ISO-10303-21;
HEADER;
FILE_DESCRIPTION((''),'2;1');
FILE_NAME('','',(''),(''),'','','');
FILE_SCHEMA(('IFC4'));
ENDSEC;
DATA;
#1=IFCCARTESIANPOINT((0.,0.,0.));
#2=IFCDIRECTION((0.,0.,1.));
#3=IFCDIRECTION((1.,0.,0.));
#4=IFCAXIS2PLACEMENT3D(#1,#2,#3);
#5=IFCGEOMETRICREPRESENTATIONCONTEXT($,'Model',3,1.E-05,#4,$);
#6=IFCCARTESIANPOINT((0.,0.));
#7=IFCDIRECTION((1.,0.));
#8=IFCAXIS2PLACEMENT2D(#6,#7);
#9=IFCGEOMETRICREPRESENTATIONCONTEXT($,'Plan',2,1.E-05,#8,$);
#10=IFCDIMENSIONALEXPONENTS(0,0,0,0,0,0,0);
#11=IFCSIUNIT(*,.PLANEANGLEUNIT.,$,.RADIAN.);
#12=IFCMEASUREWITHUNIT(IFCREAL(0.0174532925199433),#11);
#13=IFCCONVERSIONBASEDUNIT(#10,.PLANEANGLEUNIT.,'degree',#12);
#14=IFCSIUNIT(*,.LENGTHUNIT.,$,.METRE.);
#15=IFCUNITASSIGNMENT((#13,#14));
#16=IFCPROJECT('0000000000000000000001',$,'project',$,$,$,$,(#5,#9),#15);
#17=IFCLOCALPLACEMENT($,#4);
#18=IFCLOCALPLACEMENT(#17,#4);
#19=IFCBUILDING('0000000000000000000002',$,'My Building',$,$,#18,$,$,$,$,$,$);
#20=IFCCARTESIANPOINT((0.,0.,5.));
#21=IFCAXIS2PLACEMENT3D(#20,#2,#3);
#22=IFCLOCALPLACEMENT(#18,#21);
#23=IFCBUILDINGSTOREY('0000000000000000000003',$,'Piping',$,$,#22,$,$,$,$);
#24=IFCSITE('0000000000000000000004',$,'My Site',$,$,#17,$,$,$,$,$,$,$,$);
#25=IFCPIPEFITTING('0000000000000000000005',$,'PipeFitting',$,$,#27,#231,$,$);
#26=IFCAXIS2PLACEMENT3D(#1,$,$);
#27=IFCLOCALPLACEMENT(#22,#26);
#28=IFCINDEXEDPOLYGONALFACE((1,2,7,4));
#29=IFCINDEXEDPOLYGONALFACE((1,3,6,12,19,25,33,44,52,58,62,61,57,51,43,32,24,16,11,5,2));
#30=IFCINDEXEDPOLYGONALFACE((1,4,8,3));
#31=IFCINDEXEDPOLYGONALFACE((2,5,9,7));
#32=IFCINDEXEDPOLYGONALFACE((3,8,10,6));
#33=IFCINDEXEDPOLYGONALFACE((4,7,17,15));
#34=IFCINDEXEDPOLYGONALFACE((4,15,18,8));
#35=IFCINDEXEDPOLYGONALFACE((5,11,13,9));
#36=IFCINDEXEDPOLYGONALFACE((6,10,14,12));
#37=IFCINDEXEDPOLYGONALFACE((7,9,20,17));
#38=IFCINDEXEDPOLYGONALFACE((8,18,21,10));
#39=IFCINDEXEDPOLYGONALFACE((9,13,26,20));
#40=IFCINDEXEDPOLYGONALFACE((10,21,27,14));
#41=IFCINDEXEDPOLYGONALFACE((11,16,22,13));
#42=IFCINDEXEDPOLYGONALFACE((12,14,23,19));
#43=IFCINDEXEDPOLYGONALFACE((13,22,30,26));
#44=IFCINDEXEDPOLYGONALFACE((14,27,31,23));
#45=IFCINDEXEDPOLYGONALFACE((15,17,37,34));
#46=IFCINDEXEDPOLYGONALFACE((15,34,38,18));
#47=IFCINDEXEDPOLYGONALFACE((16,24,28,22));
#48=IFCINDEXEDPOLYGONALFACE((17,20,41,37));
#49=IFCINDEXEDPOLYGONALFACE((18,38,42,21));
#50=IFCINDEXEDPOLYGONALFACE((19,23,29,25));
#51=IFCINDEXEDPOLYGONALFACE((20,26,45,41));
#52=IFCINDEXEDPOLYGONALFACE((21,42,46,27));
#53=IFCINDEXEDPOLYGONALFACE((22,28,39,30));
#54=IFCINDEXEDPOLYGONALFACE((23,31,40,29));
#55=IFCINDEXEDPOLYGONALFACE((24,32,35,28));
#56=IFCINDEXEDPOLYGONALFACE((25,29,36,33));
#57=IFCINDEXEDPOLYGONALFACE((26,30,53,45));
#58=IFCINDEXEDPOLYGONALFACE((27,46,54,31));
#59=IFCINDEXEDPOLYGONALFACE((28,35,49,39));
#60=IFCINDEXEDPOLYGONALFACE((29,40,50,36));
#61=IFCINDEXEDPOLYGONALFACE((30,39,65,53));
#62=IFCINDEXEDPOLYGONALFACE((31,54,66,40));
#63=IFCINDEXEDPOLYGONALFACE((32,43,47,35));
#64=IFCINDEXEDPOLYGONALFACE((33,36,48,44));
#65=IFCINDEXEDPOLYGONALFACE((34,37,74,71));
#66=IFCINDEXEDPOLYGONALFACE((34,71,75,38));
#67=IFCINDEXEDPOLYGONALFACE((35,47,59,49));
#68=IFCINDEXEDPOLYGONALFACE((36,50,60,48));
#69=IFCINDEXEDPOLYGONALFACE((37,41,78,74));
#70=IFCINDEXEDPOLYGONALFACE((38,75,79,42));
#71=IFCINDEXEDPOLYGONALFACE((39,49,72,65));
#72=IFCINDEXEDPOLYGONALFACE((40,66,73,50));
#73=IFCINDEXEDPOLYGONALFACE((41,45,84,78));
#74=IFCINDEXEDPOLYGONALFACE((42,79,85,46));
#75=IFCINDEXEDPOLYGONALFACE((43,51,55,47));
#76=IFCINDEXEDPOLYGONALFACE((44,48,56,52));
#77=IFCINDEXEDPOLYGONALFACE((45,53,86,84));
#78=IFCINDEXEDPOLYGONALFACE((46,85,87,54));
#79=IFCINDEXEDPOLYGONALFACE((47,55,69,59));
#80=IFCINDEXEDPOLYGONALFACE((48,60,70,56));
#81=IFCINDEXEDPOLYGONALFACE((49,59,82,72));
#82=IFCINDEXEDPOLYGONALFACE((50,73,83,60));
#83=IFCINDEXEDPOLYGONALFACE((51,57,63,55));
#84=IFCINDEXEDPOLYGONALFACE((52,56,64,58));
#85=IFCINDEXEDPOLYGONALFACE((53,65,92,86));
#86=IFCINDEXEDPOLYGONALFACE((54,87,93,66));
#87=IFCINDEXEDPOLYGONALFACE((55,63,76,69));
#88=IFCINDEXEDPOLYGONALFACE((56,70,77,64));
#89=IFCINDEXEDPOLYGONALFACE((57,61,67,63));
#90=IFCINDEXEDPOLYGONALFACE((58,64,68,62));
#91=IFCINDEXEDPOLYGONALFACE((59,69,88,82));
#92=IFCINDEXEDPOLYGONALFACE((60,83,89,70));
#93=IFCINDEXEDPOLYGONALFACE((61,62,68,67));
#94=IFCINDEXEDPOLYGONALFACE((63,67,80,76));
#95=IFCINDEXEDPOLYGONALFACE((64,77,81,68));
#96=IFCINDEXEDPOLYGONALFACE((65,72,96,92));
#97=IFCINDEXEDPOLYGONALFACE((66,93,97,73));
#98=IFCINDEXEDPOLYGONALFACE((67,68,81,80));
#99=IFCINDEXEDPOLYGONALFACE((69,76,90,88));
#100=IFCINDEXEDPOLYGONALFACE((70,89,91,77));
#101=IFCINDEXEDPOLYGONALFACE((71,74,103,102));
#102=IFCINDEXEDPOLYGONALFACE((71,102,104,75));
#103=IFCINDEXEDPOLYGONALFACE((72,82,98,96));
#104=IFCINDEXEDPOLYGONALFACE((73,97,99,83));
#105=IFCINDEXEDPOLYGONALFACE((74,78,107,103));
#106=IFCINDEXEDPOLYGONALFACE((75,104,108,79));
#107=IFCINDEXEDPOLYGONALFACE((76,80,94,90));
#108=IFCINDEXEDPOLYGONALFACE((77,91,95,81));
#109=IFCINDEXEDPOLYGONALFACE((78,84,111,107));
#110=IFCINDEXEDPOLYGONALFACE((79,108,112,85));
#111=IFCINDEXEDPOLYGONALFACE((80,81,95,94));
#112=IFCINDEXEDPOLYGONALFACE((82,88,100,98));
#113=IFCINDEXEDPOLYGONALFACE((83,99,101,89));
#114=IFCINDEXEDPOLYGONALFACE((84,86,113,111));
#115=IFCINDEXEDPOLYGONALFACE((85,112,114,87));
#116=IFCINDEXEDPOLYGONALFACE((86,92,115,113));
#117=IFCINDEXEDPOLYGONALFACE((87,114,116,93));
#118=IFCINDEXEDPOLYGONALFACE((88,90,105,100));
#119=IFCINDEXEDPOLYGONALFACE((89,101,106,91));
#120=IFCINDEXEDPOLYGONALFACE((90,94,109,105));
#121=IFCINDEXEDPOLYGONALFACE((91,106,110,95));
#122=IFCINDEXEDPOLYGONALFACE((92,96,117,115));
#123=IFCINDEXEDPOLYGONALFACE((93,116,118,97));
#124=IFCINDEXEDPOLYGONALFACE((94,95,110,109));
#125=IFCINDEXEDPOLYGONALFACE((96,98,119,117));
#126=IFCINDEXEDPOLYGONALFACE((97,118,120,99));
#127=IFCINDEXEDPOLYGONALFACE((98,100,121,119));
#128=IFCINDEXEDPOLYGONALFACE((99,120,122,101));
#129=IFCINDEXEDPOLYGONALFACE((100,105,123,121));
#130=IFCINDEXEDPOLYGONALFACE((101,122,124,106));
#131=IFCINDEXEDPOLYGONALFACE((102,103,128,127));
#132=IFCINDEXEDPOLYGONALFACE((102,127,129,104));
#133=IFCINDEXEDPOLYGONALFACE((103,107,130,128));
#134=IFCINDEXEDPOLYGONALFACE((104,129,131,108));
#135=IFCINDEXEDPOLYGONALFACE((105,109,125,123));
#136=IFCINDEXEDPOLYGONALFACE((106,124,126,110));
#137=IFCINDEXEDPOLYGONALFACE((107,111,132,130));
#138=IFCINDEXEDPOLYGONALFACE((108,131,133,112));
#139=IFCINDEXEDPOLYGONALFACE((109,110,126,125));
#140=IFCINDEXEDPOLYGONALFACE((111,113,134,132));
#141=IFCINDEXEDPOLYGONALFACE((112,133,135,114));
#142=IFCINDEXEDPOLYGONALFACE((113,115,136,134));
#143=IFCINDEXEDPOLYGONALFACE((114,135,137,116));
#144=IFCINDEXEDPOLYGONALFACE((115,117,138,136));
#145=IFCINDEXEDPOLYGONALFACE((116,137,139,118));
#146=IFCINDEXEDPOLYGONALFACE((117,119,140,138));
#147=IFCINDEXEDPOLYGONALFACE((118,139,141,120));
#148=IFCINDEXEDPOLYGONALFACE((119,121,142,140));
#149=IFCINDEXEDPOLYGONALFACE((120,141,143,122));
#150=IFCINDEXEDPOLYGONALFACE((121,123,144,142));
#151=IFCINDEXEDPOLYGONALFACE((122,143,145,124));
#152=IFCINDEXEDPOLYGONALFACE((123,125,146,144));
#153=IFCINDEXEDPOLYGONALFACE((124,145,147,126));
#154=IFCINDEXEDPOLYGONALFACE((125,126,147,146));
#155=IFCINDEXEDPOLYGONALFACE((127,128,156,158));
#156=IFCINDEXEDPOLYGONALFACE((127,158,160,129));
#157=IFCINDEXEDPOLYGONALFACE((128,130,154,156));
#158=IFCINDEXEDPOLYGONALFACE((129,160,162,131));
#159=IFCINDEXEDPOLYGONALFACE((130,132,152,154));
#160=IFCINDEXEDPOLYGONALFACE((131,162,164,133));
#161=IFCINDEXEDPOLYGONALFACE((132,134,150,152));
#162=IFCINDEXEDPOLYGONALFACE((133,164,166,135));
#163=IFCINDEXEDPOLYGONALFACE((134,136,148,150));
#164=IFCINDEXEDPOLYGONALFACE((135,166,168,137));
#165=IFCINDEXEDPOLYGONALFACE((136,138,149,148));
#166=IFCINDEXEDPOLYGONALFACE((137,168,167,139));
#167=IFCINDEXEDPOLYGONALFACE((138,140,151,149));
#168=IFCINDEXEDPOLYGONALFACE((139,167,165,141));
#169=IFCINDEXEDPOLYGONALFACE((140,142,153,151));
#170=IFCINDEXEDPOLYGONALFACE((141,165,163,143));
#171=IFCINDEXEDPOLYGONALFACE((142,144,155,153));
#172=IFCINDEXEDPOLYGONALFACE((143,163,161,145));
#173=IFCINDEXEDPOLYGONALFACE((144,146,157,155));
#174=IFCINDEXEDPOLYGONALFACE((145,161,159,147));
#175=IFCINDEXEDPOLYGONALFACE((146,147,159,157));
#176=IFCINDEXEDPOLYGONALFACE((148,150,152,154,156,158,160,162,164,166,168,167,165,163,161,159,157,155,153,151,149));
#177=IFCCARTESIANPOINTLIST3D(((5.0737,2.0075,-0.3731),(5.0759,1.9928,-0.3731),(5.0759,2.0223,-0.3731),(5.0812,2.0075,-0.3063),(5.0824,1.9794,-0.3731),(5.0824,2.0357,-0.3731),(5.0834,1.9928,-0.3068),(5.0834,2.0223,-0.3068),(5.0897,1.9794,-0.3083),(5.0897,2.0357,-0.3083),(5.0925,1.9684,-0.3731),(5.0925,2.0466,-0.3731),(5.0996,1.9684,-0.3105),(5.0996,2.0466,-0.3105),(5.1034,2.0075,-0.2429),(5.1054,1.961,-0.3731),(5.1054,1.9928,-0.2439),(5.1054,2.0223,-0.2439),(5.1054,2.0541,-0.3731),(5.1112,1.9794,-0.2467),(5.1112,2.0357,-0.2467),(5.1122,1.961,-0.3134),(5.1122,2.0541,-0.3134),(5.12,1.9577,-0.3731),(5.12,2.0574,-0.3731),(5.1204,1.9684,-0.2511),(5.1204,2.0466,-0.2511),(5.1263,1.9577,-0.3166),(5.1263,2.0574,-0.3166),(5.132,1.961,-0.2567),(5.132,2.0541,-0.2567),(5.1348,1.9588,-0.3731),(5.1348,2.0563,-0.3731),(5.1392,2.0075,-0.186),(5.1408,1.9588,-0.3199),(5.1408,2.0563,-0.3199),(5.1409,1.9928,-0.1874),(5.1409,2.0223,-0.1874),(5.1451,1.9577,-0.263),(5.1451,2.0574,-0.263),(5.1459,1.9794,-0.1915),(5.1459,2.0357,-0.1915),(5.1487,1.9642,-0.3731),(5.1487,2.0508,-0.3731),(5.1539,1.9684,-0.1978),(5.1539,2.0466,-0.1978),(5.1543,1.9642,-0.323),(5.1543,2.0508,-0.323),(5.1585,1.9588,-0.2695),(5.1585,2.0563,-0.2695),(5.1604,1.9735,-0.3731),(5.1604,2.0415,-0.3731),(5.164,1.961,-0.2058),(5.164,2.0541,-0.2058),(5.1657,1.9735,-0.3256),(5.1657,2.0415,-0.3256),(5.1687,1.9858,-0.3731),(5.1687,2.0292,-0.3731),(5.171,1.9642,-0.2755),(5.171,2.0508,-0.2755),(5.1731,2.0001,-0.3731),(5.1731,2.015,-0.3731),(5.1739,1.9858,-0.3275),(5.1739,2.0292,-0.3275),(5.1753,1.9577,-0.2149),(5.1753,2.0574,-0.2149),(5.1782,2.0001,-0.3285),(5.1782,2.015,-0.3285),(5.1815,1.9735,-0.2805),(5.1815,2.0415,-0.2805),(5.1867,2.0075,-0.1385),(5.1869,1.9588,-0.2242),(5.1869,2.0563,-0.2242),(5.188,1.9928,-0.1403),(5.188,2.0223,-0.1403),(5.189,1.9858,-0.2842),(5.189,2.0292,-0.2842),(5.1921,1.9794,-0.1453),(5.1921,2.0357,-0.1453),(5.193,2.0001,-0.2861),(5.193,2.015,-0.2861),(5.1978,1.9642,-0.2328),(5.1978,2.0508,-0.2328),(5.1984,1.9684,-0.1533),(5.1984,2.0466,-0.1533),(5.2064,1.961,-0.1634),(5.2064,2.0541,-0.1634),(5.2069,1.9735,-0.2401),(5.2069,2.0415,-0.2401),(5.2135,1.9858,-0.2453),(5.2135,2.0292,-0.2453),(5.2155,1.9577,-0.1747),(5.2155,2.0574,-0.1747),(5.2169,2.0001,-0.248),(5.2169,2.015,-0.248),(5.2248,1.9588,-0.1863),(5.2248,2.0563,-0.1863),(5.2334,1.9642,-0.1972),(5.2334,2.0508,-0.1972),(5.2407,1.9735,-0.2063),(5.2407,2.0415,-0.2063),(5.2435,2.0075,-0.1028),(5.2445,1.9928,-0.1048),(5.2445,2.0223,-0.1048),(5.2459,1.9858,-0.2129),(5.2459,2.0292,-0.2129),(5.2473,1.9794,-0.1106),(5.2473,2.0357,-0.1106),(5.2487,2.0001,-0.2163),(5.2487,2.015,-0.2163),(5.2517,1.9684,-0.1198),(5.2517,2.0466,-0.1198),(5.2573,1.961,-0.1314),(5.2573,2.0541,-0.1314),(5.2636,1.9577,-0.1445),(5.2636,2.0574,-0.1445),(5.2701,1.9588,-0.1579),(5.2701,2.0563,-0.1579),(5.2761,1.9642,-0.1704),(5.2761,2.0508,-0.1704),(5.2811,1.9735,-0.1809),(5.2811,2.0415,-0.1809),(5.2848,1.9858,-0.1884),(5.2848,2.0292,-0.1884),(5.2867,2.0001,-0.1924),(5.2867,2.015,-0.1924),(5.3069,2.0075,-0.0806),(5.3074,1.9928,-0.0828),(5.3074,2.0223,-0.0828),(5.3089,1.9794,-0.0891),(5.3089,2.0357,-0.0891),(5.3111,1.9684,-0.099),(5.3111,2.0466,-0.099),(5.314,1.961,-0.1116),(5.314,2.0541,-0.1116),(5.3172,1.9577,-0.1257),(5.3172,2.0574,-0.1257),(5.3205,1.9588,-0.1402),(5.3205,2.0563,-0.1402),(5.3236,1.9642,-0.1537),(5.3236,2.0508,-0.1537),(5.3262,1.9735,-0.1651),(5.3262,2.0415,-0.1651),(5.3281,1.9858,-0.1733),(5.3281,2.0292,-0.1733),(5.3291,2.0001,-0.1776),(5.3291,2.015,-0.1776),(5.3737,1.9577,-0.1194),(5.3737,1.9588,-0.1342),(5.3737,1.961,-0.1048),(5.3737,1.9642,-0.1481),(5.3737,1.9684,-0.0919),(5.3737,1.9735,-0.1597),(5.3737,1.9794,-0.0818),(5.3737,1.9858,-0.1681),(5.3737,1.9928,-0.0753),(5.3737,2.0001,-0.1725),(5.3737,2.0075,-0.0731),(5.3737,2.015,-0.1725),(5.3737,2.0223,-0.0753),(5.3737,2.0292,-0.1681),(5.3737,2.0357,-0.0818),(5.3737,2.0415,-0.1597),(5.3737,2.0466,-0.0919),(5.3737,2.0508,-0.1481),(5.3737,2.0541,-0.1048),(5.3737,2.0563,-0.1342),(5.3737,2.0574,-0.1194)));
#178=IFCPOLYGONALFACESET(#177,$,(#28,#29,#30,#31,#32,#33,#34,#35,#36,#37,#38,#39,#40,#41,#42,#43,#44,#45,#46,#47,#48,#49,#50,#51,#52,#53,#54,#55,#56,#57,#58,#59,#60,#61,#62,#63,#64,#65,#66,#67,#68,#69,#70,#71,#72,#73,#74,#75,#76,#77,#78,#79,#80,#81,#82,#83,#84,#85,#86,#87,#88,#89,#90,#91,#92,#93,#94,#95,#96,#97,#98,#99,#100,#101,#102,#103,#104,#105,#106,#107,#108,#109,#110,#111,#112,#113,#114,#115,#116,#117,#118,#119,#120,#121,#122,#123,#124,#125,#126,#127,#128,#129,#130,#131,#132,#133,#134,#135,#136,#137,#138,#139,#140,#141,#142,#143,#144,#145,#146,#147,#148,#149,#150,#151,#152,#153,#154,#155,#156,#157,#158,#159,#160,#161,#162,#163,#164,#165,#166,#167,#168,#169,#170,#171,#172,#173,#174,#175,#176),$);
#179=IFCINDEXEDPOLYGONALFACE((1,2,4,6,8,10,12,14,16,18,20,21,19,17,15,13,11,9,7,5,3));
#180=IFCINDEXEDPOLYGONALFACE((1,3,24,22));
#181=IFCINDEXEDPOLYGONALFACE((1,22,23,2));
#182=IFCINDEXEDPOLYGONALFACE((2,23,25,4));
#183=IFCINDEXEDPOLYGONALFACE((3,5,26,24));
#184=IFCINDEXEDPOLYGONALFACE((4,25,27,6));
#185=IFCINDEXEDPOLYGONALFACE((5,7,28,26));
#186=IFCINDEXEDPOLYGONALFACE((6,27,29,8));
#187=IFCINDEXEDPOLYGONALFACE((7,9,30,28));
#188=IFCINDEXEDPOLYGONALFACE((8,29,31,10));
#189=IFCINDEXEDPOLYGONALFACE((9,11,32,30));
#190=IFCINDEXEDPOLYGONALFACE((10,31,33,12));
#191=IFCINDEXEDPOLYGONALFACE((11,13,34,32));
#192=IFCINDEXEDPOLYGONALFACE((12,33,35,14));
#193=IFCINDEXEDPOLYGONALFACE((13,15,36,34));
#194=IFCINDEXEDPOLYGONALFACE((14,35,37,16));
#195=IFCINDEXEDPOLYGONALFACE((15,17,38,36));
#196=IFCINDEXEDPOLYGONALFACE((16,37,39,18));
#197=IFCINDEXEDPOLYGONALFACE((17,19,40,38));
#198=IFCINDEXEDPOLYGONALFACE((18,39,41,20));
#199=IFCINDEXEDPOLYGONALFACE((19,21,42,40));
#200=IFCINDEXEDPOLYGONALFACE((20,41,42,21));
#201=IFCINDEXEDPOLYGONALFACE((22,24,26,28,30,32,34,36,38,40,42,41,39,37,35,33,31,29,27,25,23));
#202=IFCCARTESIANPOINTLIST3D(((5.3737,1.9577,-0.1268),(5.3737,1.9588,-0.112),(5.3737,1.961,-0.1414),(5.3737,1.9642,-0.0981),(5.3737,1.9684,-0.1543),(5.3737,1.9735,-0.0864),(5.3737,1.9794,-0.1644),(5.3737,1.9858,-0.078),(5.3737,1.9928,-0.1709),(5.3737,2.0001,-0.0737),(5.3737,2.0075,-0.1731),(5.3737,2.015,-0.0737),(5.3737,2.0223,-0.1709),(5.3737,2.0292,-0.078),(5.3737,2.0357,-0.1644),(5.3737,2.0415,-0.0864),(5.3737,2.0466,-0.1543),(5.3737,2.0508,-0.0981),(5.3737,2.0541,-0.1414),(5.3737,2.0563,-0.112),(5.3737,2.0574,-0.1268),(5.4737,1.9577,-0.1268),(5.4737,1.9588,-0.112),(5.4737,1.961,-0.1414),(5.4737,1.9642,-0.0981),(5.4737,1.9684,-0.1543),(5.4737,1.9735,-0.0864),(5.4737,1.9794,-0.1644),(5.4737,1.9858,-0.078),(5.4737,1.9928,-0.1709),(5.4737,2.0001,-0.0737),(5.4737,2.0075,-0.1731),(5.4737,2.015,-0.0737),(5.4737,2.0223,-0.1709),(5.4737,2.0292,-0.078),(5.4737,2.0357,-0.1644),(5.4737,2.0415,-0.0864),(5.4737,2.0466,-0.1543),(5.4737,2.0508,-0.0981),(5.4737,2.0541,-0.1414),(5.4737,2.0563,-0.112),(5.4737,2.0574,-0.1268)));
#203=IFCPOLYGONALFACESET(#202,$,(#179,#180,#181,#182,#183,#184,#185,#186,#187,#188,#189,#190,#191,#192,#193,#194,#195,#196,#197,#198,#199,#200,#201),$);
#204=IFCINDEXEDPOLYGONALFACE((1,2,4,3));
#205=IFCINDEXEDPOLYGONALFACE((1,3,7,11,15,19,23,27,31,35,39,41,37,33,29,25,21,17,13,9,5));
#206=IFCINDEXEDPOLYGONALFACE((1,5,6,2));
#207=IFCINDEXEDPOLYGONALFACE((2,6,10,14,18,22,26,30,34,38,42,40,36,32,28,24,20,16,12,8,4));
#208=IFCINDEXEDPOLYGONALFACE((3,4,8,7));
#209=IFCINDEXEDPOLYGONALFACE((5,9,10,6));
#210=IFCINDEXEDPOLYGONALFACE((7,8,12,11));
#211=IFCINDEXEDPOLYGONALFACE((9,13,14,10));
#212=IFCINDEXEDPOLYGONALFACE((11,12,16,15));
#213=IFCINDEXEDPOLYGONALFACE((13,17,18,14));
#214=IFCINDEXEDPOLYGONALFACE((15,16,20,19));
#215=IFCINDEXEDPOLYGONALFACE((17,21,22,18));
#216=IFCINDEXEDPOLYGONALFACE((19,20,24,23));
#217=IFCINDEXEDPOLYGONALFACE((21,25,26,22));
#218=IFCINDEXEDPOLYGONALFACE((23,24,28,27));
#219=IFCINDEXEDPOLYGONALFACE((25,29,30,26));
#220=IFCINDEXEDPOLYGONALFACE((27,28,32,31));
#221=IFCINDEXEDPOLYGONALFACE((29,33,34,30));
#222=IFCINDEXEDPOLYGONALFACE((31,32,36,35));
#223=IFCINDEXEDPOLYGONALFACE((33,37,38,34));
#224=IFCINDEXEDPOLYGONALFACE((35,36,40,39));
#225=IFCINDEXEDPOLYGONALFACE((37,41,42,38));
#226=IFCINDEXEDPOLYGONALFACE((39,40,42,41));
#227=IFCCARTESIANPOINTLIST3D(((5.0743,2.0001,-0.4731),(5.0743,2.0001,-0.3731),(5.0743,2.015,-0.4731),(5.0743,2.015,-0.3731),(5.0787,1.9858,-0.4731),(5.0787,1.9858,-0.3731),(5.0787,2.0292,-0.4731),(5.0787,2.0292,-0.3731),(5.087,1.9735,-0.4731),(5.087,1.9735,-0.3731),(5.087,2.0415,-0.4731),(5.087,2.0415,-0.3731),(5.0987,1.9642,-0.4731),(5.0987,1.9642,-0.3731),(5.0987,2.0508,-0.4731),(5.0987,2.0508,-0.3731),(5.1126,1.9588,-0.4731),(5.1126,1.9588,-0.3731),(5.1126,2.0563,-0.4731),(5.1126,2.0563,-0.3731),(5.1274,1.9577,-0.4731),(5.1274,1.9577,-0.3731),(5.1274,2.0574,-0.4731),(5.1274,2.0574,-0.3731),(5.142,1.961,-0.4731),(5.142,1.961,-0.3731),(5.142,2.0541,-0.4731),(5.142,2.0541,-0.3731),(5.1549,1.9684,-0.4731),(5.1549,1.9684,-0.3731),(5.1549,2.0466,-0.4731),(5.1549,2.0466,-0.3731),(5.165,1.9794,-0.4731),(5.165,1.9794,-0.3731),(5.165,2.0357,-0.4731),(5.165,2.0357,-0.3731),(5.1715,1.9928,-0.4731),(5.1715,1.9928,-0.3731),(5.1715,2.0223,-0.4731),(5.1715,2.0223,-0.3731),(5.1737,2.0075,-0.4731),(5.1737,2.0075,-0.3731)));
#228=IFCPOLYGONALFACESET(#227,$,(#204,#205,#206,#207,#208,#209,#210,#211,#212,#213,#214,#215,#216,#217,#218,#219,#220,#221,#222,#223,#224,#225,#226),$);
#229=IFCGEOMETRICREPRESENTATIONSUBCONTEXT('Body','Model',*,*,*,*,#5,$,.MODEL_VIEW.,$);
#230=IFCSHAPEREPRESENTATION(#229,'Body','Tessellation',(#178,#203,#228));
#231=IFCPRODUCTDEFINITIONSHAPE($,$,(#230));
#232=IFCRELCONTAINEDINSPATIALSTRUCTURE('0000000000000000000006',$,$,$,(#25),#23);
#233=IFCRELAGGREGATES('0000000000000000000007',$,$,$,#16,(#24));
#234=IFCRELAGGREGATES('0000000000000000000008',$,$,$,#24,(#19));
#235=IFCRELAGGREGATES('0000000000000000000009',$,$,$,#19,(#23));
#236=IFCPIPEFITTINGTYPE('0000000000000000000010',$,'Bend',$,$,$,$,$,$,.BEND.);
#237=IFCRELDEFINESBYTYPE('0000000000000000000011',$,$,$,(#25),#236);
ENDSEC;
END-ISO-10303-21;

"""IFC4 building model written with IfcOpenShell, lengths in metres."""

from ifc_helpers import new_model, entity, si_unit, converted_unit, frame, origin_with_axes, origin_2d_with_axis, place, context, subcontext, project, spatial, circle, extrude, source, transform, mapped, type_object, type_shapes, element, save


model = new_model("IFC4")

# Units and contexts
model_context = context("Model", 3, precision=1e-05, world=origin_with_axes())
plan_context = context("Plan", 2, precision=1e-05, world=origin_2d_with_axis())
body_context = subcontext(model_context, "Body", "Model", "MODEL_VIEW")
ifc_project = project(units=[converted_unit("PLANEANGLEUNIT", "degree", entity("IfcReal", 0.0174532925199433), si_unit("PLANEANGLEUNIT", "RADIAN"), dimensions=[0, 0, 0, 0, 0, 0, 0]), si_unit("LENGTHUNIT", "METRE")], contexts=[model_context, plan_context])

# Site, building, storey
site_placement = place(None, origin_with_axes())
site = spatial("IfcSite", under=ifc_project, at=site_placement, Name="My Site")
building_placement = place(site_placement, origin_with_axes())
building = spatial("IfcBuilding", under=site, at=building_placement, Name="My Building")
storey_placement = place(building_placement, frame((0.0, 0.0, 5.0), z_axis=(0.0, 0.0, 1.0), x_axis=(1.0, 0.0, 0.0)))
storey = spatial("IfcBuildingStorey", under=building, at=storey_placement, Name="Piping")

# Pipe fitting
pipe_fitting_type_1 = type_object("IfcPipeFittingType", Name="Bend", PredefinedType="BEND")
shared_shape = source(origin_with_axes(), body_context, "Body", "SolidModel", [
    entity("IfcSweptDiskSolid", entity("IfcIndexedPolyCurve", entity("IfcCartesianPointList3D", [[0.0, 0.0, -0.1], [0.0732, 0.0, -0.2768], [0.25, 0.0, -0.35]]), [entity("IfcArcIndex", [1, 2, 3])]), 0.05),
    extrude(circle(Radius=0.05), origin_with_axes(), (0.0, 0.0, -1.0), 0.1),
    extrude(circle(Radius=0.05), frame((0.25, 0.0, -0.35), z_axis=(1.0, 0.0, 0.0), x_axis=(0.0, 0.0, 1.0)), (0.0, 0.0, 1.0), 0.1),
])
type_shapes(pipe_fitting_type_1, [shared_shape])
for number, where, z_axis, x_axis, name in (
    (1, (5.4737, 2.0075, -0.1231), (1.0, 0.000001, 0.0), (0.0, 0.0, -1.0), "PipeFitting"),
):
    element("IfcPipeFitting", number, at=place(storey_placement, frame(where, z_axis=z_axis, x_axis=x_axis)), inside=storey, type_object=pipe_fitting_type_1, Name=name, context=body_context, shape_type="MappedRepresentation", body=[
        mapped(shared_shape, transform((0.0, 0.0, 0.0), x_axis=(1.0, 0.0, 0.0), y_axis=(0.0, 1.0, 0.0), z_axis=(0.0, 0.0, 1.0), scale=1.0)),
    ])

save(model, "model.ifc")
